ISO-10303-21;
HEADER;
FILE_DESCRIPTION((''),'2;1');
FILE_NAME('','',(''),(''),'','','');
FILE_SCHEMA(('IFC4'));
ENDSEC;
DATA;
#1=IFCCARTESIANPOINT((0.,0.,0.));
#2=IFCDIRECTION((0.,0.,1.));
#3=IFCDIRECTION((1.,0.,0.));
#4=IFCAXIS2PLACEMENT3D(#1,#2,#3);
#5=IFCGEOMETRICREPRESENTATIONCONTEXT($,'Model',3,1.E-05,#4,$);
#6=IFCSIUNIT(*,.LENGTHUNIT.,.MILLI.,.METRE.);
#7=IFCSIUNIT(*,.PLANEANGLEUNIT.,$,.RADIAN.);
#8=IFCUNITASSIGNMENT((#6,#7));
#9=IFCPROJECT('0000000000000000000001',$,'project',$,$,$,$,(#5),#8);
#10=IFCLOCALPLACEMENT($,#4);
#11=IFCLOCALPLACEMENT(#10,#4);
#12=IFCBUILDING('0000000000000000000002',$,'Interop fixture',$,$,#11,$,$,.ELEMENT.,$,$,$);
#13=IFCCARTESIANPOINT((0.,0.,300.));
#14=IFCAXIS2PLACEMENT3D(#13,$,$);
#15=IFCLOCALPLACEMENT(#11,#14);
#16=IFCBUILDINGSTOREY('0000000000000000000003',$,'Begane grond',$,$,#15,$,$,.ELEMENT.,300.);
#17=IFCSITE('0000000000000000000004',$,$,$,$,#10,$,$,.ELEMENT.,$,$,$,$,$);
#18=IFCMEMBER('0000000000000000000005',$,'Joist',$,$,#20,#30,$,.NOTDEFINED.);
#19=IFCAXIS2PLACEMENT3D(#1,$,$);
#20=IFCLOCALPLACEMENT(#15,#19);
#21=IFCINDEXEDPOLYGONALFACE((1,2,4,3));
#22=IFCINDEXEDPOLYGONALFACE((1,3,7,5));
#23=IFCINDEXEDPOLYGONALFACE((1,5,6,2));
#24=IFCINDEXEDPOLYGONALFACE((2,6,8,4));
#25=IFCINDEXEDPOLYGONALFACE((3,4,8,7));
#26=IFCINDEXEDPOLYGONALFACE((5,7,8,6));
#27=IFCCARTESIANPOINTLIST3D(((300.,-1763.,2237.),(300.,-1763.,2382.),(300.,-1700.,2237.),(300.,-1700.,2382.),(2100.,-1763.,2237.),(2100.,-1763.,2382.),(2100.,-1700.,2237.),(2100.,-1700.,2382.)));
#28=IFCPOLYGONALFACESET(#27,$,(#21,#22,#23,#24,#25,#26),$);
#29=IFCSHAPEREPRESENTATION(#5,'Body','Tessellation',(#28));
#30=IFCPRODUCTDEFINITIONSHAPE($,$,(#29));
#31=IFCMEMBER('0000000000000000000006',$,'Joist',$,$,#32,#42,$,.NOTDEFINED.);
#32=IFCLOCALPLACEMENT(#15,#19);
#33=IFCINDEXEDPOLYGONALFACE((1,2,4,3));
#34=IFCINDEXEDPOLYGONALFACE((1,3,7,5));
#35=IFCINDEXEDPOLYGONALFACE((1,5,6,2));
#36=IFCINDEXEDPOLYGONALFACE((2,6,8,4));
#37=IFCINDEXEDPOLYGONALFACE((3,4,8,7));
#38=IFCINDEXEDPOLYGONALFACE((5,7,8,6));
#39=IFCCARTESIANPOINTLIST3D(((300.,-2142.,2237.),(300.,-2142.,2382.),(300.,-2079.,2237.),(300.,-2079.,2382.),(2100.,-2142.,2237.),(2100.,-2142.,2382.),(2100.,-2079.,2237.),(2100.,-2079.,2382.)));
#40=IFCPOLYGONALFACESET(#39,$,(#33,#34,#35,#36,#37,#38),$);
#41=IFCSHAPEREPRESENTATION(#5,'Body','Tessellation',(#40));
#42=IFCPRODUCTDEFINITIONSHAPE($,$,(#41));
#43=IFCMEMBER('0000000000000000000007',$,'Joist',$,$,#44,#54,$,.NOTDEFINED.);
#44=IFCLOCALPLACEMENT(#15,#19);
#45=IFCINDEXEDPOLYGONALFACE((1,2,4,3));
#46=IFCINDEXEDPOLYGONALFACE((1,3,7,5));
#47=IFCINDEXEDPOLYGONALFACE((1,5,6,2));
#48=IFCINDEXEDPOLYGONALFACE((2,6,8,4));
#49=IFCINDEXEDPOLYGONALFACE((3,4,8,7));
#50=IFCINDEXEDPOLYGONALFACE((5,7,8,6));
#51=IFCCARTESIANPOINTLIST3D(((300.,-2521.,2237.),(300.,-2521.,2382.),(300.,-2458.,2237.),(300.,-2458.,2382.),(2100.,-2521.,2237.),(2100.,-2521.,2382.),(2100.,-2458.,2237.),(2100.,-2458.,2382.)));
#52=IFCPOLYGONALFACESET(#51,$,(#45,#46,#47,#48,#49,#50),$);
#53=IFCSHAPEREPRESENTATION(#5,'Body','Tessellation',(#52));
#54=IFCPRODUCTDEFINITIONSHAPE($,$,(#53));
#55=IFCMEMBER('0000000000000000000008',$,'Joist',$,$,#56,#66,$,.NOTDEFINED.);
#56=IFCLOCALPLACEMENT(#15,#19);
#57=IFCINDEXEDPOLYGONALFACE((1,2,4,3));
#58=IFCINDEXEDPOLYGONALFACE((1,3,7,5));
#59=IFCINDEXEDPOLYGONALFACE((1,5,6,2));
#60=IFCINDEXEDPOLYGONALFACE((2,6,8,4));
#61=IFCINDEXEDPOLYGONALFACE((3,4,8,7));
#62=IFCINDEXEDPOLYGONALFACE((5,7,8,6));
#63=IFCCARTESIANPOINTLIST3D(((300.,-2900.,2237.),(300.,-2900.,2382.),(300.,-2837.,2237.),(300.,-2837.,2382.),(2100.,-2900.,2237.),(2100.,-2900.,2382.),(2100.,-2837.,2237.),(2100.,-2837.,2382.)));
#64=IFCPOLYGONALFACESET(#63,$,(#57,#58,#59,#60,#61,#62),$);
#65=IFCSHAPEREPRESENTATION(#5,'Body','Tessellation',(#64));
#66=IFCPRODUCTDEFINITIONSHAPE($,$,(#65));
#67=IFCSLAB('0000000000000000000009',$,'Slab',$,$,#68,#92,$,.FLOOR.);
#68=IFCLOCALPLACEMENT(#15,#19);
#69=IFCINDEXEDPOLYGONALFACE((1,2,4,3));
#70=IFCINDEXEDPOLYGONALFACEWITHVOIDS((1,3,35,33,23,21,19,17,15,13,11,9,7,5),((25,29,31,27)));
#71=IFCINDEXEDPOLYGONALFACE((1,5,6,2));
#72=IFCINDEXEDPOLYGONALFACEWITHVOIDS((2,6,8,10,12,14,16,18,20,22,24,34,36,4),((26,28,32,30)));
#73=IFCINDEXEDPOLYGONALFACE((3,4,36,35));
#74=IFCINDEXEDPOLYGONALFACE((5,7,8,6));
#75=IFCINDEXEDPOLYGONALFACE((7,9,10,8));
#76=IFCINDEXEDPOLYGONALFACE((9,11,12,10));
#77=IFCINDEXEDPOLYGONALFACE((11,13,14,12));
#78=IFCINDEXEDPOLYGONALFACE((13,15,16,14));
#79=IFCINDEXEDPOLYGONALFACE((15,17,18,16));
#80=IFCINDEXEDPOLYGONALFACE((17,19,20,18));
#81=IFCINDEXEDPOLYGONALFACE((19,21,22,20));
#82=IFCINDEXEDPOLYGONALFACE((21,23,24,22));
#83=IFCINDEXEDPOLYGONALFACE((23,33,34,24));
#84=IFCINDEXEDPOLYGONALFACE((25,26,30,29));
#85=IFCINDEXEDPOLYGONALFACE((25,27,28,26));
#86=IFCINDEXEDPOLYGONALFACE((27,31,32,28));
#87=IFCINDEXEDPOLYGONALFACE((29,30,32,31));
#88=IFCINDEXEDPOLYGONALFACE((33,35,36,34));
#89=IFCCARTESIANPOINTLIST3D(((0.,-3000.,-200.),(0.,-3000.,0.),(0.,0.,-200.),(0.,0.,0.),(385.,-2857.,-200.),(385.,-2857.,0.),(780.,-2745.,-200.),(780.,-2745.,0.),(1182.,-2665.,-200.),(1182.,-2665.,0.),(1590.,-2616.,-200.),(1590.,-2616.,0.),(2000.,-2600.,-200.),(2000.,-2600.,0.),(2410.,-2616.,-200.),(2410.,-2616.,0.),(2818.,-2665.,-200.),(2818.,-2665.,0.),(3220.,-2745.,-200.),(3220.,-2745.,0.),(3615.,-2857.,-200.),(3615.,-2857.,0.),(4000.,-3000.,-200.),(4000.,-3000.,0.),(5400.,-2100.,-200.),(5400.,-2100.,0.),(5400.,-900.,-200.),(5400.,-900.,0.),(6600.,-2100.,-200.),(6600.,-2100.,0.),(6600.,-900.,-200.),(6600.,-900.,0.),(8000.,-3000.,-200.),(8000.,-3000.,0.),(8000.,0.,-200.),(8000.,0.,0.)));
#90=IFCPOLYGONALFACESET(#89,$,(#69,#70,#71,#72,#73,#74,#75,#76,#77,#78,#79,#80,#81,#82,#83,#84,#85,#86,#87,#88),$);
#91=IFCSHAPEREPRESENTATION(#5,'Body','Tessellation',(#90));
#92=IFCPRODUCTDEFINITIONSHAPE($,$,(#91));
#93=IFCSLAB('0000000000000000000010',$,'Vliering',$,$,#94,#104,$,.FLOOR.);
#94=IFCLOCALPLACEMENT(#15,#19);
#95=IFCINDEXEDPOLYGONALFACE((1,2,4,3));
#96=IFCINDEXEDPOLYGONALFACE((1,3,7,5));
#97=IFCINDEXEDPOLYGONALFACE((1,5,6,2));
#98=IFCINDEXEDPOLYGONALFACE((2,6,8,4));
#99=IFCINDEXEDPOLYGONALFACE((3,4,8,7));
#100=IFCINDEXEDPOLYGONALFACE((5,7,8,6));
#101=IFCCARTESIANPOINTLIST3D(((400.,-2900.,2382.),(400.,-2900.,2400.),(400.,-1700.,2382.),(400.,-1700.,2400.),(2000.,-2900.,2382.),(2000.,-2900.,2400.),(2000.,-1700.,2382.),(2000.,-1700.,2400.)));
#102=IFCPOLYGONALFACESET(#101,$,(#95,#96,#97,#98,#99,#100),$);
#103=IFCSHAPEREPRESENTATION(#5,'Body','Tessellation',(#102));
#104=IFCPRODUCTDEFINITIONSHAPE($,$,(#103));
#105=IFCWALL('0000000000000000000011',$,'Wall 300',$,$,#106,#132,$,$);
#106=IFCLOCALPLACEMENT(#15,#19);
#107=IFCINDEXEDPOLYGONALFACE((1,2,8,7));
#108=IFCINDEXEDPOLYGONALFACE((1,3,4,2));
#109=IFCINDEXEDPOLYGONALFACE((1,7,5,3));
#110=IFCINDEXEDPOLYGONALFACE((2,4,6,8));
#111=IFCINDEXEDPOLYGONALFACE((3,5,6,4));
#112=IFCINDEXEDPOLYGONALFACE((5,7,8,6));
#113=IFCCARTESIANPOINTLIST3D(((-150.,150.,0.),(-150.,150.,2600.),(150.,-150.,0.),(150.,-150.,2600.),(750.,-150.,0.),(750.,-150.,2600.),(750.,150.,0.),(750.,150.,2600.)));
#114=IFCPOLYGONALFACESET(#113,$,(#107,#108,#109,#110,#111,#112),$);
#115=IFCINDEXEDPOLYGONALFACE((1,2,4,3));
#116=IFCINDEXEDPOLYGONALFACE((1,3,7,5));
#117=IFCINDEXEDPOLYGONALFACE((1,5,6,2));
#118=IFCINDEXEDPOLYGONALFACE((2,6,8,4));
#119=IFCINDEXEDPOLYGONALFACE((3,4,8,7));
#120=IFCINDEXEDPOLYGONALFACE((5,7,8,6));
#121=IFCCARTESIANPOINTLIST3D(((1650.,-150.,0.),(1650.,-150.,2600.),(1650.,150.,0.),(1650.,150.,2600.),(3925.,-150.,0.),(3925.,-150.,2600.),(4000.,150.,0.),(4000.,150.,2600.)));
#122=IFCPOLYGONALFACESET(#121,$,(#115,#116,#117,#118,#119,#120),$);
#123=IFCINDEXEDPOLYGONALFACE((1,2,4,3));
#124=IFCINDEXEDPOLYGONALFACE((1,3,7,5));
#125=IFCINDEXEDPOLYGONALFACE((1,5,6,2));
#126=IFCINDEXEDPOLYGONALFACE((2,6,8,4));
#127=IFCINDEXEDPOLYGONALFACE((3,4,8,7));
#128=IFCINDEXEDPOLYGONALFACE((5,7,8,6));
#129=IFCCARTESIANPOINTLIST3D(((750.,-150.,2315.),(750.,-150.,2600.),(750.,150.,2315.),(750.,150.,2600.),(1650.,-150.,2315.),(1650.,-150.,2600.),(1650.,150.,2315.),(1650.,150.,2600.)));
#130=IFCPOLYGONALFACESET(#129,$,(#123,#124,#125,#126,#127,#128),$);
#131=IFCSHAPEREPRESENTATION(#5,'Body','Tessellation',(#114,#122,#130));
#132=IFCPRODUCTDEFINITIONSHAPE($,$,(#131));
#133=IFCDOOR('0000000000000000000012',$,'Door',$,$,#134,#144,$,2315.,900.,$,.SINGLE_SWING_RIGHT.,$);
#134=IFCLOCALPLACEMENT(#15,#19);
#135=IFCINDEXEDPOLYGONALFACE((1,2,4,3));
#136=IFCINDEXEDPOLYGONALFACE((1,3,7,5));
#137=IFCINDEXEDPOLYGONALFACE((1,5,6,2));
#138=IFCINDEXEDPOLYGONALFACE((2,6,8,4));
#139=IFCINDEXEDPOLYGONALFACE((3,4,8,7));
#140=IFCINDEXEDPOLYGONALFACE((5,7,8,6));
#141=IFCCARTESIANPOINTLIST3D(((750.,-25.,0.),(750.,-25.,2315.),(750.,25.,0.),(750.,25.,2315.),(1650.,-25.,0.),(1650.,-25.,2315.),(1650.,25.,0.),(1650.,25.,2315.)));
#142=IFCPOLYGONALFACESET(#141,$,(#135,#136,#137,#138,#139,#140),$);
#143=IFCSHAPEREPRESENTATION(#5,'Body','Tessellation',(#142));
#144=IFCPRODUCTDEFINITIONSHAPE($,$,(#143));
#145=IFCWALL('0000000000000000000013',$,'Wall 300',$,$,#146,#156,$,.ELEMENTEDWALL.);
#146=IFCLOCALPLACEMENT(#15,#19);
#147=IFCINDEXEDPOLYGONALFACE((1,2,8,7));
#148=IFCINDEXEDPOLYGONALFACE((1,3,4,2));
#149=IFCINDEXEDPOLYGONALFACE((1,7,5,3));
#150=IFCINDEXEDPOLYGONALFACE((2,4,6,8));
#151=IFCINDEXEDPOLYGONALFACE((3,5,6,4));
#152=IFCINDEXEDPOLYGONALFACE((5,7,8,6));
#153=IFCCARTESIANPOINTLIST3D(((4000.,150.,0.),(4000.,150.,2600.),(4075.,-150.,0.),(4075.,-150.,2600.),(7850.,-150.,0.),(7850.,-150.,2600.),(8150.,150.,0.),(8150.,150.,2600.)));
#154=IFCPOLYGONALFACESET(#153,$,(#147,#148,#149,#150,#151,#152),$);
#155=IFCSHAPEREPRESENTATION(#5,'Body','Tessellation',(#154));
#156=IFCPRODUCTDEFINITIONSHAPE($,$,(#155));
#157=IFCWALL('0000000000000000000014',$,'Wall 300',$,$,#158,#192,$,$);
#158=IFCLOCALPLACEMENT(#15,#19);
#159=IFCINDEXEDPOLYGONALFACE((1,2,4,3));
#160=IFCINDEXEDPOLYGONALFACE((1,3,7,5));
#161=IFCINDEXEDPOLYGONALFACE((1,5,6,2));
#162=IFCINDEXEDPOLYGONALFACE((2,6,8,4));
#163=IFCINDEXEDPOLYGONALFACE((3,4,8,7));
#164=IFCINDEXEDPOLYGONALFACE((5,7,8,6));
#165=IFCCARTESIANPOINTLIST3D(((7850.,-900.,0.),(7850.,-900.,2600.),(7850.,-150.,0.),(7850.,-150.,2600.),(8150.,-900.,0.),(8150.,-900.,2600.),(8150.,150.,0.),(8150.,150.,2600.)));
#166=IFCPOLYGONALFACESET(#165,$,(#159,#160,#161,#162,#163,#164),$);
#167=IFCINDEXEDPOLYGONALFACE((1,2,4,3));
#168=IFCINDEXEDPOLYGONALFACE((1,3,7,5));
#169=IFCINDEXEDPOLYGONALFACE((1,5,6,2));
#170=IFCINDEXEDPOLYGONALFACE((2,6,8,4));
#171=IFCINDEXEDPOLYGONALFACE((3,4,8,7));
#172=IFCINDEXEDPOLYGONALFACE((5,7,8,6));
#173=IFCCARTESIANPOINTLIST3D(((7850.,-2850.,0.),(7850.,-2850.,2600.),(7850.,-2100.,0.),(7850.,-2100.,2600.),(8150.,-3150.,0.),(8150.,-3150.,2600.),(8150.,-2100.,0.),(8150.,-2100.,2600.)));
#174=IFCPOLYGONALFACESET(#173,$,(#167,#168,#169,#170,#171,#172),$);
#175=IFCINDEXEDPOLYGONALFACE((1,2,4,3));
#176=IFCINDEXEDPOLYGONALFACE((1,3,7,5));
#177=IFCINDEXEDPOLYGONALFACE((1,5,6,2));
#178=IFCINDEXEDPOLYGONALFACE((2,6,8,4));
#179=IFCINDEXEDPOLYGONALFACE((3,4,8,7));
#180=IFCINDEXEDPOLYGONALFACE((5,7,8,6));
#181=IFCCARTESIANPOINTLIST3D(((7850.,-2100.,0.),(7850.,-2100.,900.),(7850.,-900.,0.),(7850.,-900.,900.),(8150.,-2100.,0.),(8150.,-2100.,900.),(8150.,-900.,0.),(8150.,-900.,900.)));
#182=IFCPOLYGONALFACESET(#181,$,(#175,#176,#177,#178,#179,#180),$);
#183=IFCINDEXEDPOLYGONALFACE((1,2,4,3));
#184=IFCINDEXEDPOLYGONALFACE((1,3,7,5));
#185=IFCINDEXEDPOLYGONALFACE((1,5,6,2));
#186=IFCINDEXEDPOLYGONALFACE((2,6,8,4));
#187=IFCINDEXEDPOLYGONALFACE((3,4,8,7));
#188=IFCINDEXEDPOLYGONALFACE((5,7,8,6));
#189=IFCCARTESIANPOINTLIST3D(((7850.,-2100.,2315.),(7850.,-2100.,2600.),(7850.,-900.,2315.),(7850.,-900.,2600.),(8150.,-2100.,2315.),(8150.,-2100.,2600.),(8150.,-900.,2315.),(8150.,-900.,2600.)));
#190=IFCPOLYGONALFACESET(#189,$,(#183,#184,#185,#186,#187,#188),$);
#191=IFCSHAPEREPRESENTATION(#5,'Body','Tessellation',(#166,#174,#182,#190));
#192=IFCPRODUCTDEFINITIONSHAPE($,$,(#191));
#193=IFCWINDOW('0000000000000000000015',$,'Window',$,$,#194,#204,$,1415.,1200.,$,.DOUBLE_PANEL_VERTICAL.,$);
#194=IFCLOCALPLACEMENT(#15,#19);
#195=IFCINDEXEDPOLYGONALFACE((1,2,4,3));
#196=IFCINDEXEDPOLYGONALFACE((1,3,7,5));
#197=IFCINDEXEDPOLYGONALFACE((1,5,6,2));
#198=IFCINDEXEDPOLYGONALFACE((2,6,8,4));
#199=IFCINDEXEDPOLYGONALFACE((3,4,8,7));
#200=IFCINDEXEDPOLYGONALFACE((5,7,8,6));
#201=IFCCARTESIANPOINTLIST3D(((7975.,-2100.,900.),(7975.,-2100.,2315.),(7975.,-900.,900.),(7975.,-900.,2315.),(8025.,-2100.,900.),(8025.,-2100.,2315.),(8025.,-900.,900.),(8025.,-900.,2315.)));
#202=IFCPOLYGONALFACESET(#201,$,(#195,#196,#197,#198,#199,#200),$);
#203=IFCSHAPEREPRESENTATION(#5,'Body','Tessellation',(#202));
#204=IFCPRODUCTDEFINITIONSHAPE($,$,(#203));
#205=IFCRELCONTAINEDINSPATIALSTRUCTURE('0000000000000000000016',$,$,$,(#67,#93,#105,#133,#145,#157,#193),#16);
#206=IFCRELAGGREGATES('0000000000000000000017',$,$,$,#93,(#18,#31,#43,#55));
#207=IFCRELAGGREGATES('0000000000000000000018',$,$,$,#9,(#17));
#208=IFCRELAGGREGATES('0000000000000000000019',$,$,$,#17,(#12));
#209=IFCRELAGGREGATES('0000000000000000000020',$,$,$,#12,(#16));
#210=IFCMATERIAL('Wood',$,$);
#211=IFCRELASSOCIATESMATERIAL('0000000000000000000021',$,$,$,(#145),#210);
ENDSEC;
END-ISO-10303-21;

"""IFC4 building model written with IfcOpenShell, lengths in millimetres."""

from ifc_helpers import new_model, si_unit, frame, origin, origin_with_axes, place, context, project, spatial, polyline, outline, extrude, material, element, fill, aggregate, save


model = new_model("IFC4")

# Units and contexts
model_context = context("Model", 3, precision=1e-05, world=origin_with_axes())
ifc_project = project(units=[si_unit("LENGTHUNIT", "METRE", prefix="MILLI"), si_unit("PLANEANGLEUNIT", "RADIAN")], contexts=[model_context])

# Members
site_placement = place(None, origin_with_axes())
building_placement = place(site_placement, origin_with_axes())
storey_placement = place(building_placement, frame((0.0, 0.0, 300.0)))
placement = place(storey_placement, origin_with_axes())
member_1 = element("IfcMember", 1, at=placement, Name="Joist", PredefinedType="NOTDEFINED", context=model_context, shape_type="SweptSolid", body=[
    extrude(outline(polyline([(300.0, -1700.0), (2100.0, -1700.0), (2100.0, -1763.0), (300.0, -1763.0), (300.0, -1700.0)])), frame((0.0, 0.0, 2237.0)), (0.0, 0.0, 1.0), 145.0),
])
member_2 = element("IfcMember", 2, at=placement, Name="Joist", PredefinedType="NOTDEFINED", context=model_context, shape_type="SweptSolid", body=[
    extrude(outline(polyline([(300.0, -2079.0), (2100.0, -2079.0), (2100.0, -2142.0), (300.0, -2142.0), (300.0, -2079.0)])), frame((0.0, 0.0, 2237.0)), (0.0, 0.0, 1.0), 145.0),
])
member_3 = element("IfcMember", 3, at=placement, Name="Joist", PredefinedType="NOTDEFINED", context=model_context, shape_type="SweptSolid", body=[
    extrude(outline(polyline([(300.0, -2458.0), (2100.0, -2458.0), (2100.0, -2521.0), (300.0, -2521.0), (300.0, -2458.0)])), frame((0.0, 0.0, 2237.0)), (0.0, 0.0, 1.0), 145.0),
])
member_4 = element("IfcMember", 4, at=placement, Name="Joist", PredefinedType="NOTDEFINED", context=model_context, shape_type="SweptSolid", body=[
    extrude(outline(polyline([(300.0, -2837.0), (2100.0, -2837.0), (2100.0, -2900.0), (300.0, -2900.0), (300.0, -2837.0)])), frame((0.0, 0.0, 2237.0)), (0.0, 0.0, 1.0), 145.0),
])

# Site, building, storey
site = spatial("IfcSite", under=ifc_project, at=site_placement, CompositionType="ELEMENT")
building = spatial("IfcBuilding", under=site, at=building_placement, Name="Interop fixture", CompositionType="ELEMENT")
storey = spatial("IfcBuildingStorey", under=building, at=storey_placement, Name="Begane grond", CompositionType="ELEMENT", Elevation=300.0)

# Slab, opening
slab_1 = element("IfcSlab", 5, at=placement, inside=storey, Name="Slab", PredefinedType="FLOOR", context=model_context, shape_type="SweptSolid", body=[
    extrude(outline(polyline([(4000.0, 0.0), (0.0, 0.0), (0.0, -3000.0), (385.0, -2857.0), (780.0, -2745.0), (1182.0, -2665.0), (1590.0, -2616.0), (2000.0, -2600.0), (2410.0, -2616.0), (2818.0, -2665.0), (3220.0, -2745.0), (3615.0, -2857.0), (4000.0, -3000.0), (8000.0, -3000.0), (8000.0, 0.0), (4000.0, 0.0)])), frame((0.0, 0.0, -200.0)), (0.0, 0.0, 1.0), 200.0),
])
element("IfcOpeningElement", 6, at=placement, cuts=slab_1, context=model_context, shape_type="SweptSolid", body=[
    extrude(outline(polyline([(5400.0, -900.0), (6600.0, -900.0), (6600.0, -2100.0), (5400.0, -2100.0), (5400.0, -900.0)])), frame((0.0, 0.0, -200.0)), (0.0, 0.0, 1.0), 200.0),
])

# Slab
slab_2 = element("IfcSlab", 7, at=placement, inside=storey, Name="Vliering", PredefinedType="FLOOR", context=model_context, shape_type="SweptSolid", body=[
    extrude(outline(polyline([(400.0, -1700.0), (2000.0, -1700.0), (2000.0, -2900.0), (400.0, -2900.0), (400.0, -1700.0)])), frame((0.0, 0.0, 2382.0)), (0.0, 0.0, 1.0), 18.0),
])
aggregate(slab_2, [member_1, member_2, member_3, member_4])

# Wall, opening, door
wall_1 = element("IfcWall", 8, at=placement, inside=storey, Name="Wall 300", context=model_context, shape_type="SweptSolid", body=[
    extrude(outline(polyline([(150.0, -150.0), (750.0, -150.0), (750.0, 150.0), (-150.0, 150.0), (150.0, -150.0)])), origin(), (0.0, 0.0, 1.0), 2600.0),
    extrude(outline(polyline([(1650.0, -150.0), (3925.0, -150.0), (4000.0, 150.0), (1650.0, 150.0), (1650.0, -150.0)])), origin(), (0.0, 0.0, 1.0), 2600.0),
    extrude(outline(polyline([(750.0, -150.0), (1650.0, -150.0), (1650.0, 150.0), (750.0, 150.0), (750.0, -150.0)])), frame((0.0, 0.0, 2315.0)), (0.0, 0.0, 1.0), 285.0),
])
opening_1 = element("IfcOpeningElement", 9, at=placement, cuts=wall_1, context=model_context, shape_type="SweptSolid", body=[
    extrude(outline(polyline([(750.0, -150.0), (1650.0, -150.0), (1650.0, 150.0), (750.0, 150.0), (750.0, -150.0)])), origin(), (0.0, 0.0, 1.0), 2315.0),
])
door = element("IfcDoor", 10, at=placement, inside=storey, Name="Door", OperationType="SINGLE_SWING_RIGHT", OverallHeight=2315.0, OverallWidth=900.0, context=model_context, shape_type="SweptSolid", body=[
    extrude(outline(polyline([(750.0, -25.0), (1650.0, -25.0), (1650.0, 25.0), (750.0, 25.0), (750.0, -25.0)])), origin(), (0.0, 0.0, 1.0), 2315.0),
])
fill(opening_1, door)

# Wall
ifc_material_1 = material(Name="Wood")
element("IfcWall", 11, at=placement, inside=storey, material=ifc_material_1, Name="Wall 300", PredefinedType="ELEMENTEDWALL", context=model_context, shape_type="SweptSolid", body=[
    extrude(outline(polyline([(4075.0, -150.0), (7850.0, -150.0), (8150.0, 150.0), (4000.0, 150.0), (4075.0, -150.0)])), origin(), (0.0, 0.0, 1.0), 2600.0),
])

# Wall, opening, window
wall_2 = element("IfcWall", 12, at=placement, inside=storey, Name="Wall 300", context=model_context, shape_type="SweptSolid", body=[
    extrude(outline(polyline([(7850.0, -150.0), (7850.0, -900.0), (8150.0, -900.0), (8150.0, 150.0), (7850.0, -150.0)])), origin(), (0.0, 0.0, 1.0), 2600.0),
    extrude(outline(polyline([(7850.0, -2100.0), (7850.0, -2850.0), (8150.0, -3150.0), (8150.0, -2100.0), (7850.0, -2100.0)])), origin(), (0.0, 0.0, 1.0), 2600.0),
    extrude(outline(polyline([(7850.0, -900.0), (7850.0, -2100.0), (8150.0, -2100.0), (8150.0, -900.0), (7850.0, -900.0)])), origin(), (0.0, 0.0, 1.0), 900.0),
    extrude(outline(polyline([(7850.0, -900.0), (7850.0, -2100.0), (8150.0, -2100.0), (8150.0, -900.0), (7850.0, -900.0)])), frame((0.0, 0.0, 2315.0)), (0.0, 0.0, 1.0), 285.0),
])
opening_2 = element("IfcOpeningElement", 13, at=placement, cuts=wall_2, context=model_context, shape_type="SweptSolid", body=[
    extrude(outline(polyline([(7850.0, -900.0), (7850.0, -2100.0), (8150.0, -2100.0), (8150.0, -900.0), (7850.0, -900.0)])), frame((0.0, 0.0, 900.0)), (0.0, 0.0, 1.0), 1415.0),
])
window = element("IfcWindow", 14, at=placement, inside=storey, Name="Window", OverallHeight=1415.0, OverallWidth=1200.0, PartitioningType="DOUBLE_PANEL_VERTICAL", context=model_context, shape_type="SweptSolid", body=[
    extrude(outline(polyline([(7975.0, -900.0), (7975.0, -2100.0), (8025.0, -2100.0), (8025.0, -900.0), (7975.0, -900.0)])), frame((0.0, 0.0, 900.0)), (0.0, 0.0, 1.0), 1415.0),
])
fill(opening_2, window)

save(model, "model.ifc")
